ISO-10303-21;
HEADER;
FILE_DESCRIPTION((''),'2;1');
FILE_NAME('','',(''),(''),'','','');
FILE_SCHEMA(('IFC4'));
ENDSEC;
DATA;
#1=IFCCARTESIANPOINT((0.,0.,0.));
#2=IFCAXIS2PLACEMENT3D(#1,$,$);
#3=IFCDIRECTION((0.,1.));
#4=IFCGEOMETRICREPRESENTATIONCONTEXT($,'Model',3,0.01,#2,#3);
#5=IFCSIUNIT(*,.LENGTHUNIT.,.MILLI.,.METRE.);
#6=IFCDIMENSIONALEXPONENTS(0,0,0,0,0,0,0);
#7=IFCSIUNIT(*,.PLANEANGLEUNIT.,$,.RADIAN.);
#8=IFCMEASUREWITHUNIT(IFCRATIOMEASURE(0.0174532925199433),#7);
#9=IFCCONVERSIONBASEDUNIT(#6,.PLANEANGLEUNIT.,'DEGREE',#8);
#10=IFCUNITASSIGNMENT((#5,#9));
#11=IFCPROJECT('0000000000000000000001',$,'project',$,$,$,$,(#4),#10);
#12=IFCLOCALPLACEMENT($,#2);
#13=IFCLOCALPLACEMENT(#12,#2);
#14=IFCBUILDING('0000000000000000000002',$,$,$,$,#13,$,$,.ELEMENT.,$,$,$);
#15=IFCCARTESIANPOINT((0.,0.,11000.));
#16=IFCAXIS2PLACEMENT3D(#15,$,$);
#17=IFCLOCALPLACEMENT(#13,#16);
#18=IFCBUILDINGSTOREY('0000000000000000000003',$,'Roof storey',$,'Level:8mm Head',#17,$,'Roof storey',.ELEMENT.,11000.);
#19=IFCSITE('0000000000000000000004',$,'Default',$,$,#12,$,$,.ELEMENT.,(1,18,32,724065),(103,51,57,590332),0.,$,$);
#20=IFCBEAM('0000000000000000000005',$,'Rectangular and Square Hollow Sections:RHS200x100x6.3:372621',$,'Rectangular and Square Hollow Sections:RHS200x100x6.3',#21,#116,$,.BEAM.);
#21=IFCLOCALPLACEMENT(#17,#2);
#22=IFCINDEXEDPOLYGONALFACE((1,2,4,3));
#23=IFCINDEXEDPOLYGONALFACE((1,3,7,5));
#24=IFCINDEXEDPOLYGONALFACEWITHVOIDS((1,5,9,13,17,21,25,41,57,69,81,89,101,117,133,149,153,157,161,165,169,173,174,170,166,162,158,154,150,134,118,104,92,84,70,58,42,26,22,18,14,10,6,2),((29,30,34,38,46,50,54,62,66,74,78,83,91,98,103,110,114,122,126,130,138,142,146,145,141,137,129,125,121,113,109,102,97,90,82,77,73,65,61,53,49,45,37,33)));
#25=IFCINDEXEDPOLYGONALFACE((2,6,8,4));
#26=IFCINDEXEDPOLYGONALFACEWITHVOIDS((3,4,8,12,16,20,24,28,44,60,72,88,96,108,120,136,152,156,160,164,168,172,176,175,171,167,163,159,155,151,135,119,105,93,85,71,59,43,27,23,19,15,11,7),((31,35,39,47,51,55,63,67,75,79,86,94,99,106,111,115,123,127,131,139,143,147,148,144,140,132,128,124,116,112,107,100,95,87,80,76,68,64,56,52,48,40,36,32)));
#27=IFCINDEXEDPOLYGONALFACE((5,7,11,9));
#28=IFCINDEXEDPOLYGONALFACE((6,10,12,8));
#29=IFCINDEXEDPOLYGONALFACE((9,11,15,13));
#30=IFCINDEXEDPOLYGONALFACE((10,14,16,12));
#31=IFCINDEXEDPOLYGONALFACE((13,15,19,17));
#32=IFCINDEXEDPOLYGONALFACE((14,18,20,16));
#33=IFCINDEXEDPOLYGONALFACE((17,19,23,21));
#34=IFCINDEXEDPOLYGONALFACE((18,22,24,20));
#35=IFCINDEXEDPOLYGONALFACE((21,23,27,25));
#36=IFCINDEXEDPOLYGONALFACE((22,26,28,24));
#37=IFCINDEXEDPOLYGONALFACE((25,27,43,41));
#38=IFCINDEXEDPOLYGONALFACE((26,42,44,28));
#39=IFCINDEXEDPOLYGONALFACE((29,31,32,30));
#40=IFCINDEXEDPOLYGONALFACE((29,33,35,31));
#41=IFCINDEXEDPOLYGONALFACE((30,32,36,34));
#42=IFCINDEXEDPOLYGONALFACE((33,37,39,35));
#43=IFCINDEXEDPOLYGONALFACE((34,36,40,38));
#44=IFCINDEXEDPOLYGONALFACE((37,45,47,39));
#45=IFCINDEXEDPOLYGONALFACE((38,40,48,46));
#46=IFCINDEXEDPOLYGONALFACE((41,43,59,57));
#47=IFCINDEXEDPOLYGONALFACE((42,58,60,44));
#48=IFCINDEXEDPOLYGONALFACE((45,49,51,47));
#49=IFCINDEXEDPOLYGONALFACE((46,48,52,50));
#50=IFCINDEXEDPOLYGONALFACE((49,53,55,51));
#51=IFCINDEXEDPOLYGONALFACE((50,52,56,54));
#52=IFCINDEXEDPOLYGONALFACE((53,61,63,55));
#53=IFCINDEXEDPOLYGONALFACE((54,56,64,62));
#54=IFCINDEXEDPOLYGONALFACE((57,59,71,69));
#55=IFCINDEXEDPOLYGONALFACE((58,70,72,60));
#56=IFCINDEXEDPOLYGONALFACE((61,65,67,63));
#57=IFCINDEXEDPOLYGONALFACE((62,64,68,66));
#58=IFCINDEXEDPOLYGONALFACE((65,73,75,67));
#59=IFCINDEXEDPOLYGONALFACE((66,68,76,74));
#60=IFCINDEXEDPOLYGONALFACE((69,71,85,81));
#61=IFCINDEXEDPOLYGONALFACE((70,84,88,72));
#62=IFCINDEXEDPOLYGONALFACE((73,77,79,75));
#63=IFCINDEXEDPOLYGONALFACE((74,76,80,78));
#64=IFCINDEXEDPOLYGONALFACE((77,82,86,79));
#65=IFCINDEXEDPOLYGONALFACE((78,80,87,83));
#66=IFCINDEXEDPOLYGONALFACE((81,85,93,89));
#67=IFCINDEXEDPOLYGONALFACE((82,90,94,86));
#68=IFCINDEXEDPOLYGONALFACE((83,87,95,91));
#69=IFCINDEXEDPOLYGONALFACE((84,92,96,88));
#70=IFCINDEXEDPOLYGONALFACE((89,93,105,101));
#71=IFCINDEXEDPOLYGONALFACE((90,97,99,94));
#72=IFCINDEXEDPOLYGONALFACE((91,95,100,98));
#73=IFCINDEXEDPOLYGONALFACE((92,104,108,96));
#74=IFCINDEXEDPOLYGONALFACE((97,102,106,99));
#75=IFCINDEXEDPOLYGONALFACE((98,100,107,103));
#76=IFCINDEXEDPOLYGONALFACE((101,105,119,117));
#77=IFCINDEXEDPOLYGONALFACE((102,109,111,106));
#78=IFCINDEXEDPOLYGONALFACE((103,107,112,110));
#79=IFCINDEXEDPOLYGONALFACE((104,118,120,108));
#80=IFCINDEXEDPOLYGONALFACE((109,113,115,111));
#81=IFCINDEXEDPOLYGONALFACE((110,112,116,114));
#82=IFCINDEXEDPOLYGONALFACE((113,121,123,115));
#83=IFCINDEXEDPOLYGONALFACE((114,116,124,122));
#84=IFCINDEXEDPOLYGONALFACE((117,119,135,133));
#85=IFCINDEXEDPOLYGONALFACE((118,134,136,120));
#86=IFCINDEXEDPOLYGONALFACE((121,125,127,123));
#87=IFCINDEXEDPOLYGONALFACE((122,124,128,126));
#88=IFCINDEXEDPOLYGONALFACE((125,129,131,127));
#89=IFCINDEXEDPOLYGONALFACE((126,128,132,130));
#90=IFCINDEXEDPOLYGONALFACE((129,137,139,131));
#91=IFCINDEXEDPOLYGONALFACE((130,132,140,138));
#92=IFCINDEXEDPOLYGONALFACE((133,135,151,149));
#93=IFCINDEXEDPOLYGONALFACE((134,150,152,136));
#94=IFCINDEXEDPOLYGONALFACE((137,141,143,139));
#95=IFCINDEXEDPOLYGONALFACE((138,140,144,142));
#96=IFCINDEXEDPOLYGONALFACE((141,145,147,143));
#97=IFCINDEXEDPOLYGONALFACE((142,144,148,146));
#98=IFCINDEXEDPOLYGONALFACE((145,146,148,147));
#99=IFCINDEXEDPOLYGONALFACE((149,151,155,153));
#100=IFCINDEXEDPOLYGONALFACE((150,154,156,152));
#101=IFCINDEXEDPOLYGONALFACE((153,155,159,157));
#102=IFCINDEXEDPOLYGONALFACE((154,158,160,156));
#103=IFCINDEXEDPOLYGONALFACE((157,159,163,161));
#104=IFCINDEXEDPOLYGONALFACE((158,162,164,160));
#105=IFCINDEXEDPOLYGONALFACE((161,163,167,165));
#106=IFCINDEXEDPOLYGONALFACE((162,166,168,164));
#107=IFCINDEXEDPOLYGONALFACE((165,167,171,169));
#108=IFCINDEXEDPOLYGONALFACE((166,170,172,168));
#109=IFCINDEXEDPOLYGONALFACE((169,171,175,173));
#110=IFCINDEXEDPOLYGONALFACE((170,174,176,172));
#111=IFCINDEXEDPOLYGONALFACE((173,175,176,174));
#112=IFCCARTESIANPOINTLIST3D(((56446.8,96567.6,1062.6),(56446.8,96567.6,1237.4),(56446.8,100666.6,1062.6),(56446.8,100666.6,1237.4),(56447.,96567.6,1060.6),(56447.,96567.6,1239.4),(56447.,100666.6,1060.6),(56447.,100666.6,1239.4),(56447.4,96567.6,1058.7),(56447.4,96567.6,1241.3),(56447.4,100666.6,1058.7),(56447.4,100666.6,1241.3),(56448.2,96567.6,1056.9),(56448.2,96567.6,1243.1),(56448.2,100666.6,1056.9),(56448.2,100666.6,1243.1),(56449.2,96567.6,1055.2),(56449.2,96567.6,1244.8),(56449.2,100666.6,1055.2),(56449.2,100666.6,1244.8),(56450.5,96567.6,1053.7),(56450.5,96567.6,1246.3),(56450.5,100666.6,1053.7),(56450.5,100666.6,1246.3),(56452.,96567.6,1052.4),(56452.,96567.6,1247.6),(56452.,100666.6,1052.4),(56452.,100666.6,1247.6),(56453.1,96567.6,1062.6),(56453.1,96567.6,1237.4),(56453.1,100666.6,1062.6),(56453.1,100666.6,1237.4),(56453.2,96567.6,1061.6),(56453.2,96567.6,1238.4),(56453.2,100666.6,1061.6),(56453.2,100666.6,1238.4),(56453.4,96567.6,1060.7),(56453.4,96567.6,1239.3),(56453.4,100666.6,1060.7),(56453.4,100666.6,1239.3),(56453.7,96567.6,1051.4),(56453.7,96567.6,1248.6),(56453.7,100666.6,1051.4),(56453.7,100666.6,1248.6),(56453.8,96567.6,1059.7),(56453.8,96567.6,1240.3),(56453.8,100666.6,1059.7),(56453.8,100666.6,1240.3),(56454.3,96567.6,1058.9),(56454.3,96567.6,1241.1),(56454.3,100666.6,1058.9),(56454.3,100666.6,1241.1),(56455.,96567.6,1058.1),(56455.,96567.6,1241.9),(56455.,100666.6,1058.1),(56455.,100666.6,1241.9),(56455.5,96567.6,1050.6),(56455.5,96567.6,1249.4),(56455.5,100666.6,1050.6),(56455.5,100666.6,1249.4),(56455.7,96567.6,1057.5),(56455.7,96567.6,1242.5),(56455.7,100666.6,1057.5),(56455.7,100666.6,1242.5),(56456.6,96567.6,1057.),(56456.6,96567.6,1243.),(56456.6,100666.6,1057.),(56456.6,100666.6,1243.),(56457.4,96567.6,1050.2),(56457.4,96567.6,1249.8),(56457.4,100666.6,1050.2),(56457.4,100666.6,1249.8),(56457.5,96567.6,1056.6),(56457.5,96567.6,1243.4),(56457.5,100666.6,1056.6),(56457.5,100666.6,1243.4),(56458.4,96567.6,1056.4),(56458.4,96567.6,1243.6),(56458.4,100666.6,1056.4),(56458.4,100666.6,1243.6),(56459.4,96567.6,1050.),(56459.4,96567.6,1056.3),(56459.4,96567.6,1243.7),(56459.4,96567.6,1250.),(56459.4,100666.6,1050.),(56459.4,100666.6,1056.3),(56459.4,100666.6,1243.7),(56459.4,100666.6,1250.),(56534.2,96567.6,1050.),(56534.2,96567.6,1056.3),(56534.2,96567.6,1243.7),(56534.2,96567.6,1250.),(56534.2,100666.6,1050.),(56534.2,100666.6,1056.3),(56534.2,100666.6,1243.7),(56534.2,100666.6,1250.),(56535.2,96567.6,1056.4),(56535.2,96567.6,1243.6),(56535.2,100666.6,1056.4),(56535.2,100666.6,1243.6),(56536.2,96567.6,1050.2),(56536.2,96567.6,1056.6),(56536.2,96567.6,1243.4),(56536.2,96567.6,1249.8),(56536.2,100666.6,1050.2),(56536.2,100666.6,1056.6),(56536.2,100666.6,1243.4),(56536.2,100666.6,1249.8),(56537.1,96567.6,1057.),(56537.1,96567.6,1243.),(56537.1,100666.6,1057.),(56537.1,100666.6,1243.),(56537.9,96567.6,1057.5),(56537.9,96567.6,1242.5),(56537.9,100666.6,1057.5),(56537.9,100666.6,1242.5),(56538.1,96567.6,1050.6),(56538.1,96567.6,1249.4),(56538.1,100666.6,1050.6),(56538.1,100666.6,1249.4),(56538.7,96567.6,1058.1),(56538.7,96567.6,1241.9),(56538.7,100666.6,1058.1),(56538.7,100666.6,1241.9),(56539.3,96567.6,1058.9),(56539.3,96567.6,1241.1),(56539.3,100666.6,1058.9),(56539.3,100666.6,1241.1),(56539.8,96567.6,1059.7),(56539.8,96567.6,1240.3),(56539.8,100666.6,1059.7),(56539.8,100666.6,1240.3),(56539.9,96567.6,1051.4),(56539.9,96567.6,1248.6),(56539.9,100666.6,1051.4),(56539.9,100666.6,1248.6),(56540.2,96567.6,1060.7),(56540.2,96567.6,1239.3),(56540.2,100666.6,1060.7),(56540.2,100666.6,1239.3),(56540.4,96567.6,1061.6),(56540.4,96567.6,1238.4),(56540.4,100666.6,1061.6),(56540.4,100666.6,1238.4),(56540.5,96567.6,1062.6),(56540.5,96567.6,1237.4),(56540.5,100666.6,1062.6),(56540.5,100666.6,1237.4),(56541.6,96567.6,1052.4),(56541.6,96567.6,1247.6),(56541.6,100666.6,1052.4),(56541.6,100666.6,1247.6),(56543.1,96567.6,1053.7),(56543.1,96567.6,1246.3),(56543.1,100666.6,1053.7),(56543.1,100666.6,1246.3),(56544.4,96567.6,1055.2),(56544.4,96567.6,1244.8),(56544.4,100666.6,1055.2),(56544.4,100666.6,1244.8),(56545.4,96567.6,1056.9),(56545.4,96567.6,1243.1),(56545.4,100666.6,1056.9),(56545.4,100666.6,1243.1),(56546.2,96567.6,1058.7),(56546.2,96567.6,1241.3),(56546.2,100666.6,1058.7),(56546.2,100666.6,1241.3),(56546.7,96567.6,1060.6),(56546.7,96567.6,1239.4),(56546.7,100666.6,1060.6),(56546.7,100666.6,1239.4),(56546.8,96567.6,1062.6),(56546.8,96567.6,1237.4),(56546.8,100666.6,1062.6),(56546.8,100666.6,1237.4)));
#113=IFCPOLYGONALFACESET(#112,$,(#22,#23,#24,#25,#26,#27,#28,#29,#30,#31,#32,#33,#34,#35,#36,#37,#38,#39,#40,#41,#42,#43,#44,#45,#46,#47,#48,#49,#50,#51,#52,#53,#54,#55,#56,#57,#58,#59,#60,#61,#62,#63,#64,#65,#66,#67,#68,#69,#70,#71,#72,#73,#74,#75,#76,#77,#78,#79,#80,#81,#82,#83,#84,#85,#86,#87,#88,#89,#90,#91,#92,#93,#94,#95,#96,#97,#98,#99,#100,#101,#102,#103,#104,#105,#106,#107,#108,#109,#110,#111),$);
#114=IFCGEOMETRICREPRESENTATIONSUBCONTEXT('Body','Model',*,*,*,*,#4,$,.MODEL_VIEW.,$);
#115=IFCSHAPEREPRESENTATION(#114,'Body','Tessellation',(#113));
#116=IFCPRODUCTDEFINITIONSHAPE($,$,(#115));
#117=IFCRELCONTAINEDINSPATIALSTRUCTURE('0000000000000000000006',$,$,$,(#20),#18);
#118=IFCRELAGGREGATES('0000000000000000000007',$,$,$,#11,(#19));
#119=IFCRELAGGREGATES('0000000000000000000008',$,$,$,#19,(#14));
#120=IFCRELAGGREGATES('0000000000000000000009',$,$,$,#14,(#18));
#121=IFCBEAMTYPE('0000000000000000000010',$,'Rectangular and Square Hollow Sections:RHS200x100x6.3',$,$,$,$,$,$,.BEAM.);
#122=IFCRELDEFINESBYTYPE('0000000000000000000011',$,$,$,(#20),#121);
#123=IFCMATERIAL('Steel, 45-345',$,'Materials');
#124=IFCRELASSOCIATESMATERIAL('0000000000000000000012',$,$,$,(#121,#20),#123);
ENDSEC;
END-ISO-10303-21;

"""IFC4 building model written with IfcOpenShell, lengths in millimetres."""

from ifc_helpers import new_model, entity, si_unit, converted_unit, direction, frame, origin, place, context, subcontext, project, spatial, indexed_curve, outline, extrude, source, transform, mapped, material, type_object, type_shapes, element, save


model = new_model("IFC4")

# Units and contexts
model_context = context("Model", 3, precision=0.01, world=origin(), true_north=direction((0.0, 1.0)))
body_context = subcontext(model_context, "Body", "Model", "MODEL_VIEW")
ifc_project = project(units=[si_unit("LENGTHUNIT", "METRE", prefix="MILLI"), converted_unit("PLANEANGLEUNIT", "DEGREE", entity("IfcRatioMeasure", 0.0174532925199433), si_unit("PLANEANGLEUNIT", "RADIAN"), dimensions=[0, 0, 0, 0, 0, 0, 0])], contexts=[model_context])

# Site, building, storey
site_placement = place(None, origin())
site = spatial("IfcSite", under=ifc_project, at=site_placement, Name="Default", CompositionType="ELEMENT", RefLatitude=(1, 18, 32, 724065), RefLongitude=(103, 51, 57, 590332), RefElevation=0.0)
building_placement = place(site_placement, origin())
building = spatial("IfcBuilding", under=site, at=building_placement, CompositionType="ELEMENT")
storey_placement = place(building_placement, frame((0.0, 0.0, 11000.0)))
storey = spatial("IfcBuildingStorey", under=building, at=storey_placement, Name="Roof storey", ObjectType="Level:8mm Head", LongName="Roof storey", CompositionType="ELEMENT", Elevation=11000.0)

# Shared definitions
ifc_material = material(Name="Steel, 45-345", Category="Materials")

# Beam
beam_type_1 = type_object("IfcBeamType", Name="Rectangular and Square Hollow Sections:RHS200x100x6.3", PredefinedType="BEAM", material=ifc_material)
shared_shape_1 = source(origin(), body_context, "Body", "SweptSolid", [
    extrude(outline(indexed_curve([(87.4, -50.0), (89.4, -49.8), (91.3, -49.4), (93.1, -48.6), (94.8, -47.6), (96.3, -46.3), (97.6, -44.8), (98.6, -43.1), (99.4, -41.3), (99.8, -39.4), (100.0, -37.4), (100.0, 37.4), (99.8, 39.4), (99.4, 41.3), (98.6, 43.1), (97.6, 44.8), (96.3, 46.3), (94.8, 47.6), (93.1, 48.6), (91.3, 49.4), (89.4, 49.8), (87.4, 50.0), (-87.4, 50.0), (-89.4, 49.8), (-91.3, 49.4), (-93.1, 48.6), (-94.8, 47.6), (-96.3, 46.3), (-97.6, 44.8), (-98.6, 43.1), (-99.4, 41.3), (-99.8, 39.4), (-100.0, 37.4), (-100.0, -37.4), (-99.8, -39.4), (-99.4, -41.3), (-98.6, -43.1), (-97.6, -44.8), (-96.3, -46.3), (-94.8, -47.6), (-93.1, -48.6), (-91.3, -49.4), (-89.4, -49.8), (-87.4, -50.0), (87.4, -50.0)], self_intersect=False), holes=[indexed_curve([(93.7, 37.4), (93.7, -37.4), (93.6, -38.4), (93.4, -39.3), (93.0, -40.3), (92.5, -41.1), (91.9, -41.9), (91.1, -42.5), (90.3, -43.0), (89.3, -43.4), (88.4, -43.6), (87.4, -43.7), (-87.4, -43.7), (-88.4, -43.6), (-89.3, -43.4), (-90.3, -43.0), (-91.1, -42.5), (-91.9, -41.9), (-92.5, -41.1), (-93.0, -40.3), (-93.4, -39.3), (-93.6, -38.4), (-93.7, -37.4), (-93.7, 37.4), (-93.6, 38.4), (-93.4, 39.3), (-93.0, 40.3), (-92.5, 41.1), (-91.9, 41.9), (-91.1, 42.5), (-90.3, 43.0), (-89.3, 43.4), (-88.4, 43.6), (-87.4, 43.7), (87.4, 43.7), (88.4, 43.6), (89.3, 43.4), (90.3, 43.0), (91.1, 42.5), (91.9, 41.9), (92.5, 41.1), (93.0, 40.3), (93.4, 39.3), (93.6, 38.4), (93.7, 37.4)], self_intersect=False)]), frame((-2049.5, 0.0, 0.0), z_axis=(1.0, 0.0, 0.0), x_axis=(0.0, 0.0, 1.0)), (0.0, 0.0, 1.0), 4099.0),
])
type_shapes(beam_type_1, [shared_shape_1])
beam_1_placement = place(storey_placement, frame((56496.8, 98617.1, 1150.0), z_axis=(0.0, 0.0, 1.0), x_axis=(0.0, 1.0, 0.0)))
element("IfcBeam", 1, at=beam_1_placement, inside=storey, type_object=beam_type_1, material=ifc_material, Name="Rectangular and Square Hollow Sections:RHS200x100x6.3:372621", ObjectType="Rectangular and Square Hollow Sections:RHS200x100x6.3", PredefinedType="BEAM", context=body_context, shape_type="MappedRepresentation", body=[
    mapped(shared_shape_1, transform((0.0, 0.0, 0.0), scale=1.0)),
])

save(model, "model.ifc")
